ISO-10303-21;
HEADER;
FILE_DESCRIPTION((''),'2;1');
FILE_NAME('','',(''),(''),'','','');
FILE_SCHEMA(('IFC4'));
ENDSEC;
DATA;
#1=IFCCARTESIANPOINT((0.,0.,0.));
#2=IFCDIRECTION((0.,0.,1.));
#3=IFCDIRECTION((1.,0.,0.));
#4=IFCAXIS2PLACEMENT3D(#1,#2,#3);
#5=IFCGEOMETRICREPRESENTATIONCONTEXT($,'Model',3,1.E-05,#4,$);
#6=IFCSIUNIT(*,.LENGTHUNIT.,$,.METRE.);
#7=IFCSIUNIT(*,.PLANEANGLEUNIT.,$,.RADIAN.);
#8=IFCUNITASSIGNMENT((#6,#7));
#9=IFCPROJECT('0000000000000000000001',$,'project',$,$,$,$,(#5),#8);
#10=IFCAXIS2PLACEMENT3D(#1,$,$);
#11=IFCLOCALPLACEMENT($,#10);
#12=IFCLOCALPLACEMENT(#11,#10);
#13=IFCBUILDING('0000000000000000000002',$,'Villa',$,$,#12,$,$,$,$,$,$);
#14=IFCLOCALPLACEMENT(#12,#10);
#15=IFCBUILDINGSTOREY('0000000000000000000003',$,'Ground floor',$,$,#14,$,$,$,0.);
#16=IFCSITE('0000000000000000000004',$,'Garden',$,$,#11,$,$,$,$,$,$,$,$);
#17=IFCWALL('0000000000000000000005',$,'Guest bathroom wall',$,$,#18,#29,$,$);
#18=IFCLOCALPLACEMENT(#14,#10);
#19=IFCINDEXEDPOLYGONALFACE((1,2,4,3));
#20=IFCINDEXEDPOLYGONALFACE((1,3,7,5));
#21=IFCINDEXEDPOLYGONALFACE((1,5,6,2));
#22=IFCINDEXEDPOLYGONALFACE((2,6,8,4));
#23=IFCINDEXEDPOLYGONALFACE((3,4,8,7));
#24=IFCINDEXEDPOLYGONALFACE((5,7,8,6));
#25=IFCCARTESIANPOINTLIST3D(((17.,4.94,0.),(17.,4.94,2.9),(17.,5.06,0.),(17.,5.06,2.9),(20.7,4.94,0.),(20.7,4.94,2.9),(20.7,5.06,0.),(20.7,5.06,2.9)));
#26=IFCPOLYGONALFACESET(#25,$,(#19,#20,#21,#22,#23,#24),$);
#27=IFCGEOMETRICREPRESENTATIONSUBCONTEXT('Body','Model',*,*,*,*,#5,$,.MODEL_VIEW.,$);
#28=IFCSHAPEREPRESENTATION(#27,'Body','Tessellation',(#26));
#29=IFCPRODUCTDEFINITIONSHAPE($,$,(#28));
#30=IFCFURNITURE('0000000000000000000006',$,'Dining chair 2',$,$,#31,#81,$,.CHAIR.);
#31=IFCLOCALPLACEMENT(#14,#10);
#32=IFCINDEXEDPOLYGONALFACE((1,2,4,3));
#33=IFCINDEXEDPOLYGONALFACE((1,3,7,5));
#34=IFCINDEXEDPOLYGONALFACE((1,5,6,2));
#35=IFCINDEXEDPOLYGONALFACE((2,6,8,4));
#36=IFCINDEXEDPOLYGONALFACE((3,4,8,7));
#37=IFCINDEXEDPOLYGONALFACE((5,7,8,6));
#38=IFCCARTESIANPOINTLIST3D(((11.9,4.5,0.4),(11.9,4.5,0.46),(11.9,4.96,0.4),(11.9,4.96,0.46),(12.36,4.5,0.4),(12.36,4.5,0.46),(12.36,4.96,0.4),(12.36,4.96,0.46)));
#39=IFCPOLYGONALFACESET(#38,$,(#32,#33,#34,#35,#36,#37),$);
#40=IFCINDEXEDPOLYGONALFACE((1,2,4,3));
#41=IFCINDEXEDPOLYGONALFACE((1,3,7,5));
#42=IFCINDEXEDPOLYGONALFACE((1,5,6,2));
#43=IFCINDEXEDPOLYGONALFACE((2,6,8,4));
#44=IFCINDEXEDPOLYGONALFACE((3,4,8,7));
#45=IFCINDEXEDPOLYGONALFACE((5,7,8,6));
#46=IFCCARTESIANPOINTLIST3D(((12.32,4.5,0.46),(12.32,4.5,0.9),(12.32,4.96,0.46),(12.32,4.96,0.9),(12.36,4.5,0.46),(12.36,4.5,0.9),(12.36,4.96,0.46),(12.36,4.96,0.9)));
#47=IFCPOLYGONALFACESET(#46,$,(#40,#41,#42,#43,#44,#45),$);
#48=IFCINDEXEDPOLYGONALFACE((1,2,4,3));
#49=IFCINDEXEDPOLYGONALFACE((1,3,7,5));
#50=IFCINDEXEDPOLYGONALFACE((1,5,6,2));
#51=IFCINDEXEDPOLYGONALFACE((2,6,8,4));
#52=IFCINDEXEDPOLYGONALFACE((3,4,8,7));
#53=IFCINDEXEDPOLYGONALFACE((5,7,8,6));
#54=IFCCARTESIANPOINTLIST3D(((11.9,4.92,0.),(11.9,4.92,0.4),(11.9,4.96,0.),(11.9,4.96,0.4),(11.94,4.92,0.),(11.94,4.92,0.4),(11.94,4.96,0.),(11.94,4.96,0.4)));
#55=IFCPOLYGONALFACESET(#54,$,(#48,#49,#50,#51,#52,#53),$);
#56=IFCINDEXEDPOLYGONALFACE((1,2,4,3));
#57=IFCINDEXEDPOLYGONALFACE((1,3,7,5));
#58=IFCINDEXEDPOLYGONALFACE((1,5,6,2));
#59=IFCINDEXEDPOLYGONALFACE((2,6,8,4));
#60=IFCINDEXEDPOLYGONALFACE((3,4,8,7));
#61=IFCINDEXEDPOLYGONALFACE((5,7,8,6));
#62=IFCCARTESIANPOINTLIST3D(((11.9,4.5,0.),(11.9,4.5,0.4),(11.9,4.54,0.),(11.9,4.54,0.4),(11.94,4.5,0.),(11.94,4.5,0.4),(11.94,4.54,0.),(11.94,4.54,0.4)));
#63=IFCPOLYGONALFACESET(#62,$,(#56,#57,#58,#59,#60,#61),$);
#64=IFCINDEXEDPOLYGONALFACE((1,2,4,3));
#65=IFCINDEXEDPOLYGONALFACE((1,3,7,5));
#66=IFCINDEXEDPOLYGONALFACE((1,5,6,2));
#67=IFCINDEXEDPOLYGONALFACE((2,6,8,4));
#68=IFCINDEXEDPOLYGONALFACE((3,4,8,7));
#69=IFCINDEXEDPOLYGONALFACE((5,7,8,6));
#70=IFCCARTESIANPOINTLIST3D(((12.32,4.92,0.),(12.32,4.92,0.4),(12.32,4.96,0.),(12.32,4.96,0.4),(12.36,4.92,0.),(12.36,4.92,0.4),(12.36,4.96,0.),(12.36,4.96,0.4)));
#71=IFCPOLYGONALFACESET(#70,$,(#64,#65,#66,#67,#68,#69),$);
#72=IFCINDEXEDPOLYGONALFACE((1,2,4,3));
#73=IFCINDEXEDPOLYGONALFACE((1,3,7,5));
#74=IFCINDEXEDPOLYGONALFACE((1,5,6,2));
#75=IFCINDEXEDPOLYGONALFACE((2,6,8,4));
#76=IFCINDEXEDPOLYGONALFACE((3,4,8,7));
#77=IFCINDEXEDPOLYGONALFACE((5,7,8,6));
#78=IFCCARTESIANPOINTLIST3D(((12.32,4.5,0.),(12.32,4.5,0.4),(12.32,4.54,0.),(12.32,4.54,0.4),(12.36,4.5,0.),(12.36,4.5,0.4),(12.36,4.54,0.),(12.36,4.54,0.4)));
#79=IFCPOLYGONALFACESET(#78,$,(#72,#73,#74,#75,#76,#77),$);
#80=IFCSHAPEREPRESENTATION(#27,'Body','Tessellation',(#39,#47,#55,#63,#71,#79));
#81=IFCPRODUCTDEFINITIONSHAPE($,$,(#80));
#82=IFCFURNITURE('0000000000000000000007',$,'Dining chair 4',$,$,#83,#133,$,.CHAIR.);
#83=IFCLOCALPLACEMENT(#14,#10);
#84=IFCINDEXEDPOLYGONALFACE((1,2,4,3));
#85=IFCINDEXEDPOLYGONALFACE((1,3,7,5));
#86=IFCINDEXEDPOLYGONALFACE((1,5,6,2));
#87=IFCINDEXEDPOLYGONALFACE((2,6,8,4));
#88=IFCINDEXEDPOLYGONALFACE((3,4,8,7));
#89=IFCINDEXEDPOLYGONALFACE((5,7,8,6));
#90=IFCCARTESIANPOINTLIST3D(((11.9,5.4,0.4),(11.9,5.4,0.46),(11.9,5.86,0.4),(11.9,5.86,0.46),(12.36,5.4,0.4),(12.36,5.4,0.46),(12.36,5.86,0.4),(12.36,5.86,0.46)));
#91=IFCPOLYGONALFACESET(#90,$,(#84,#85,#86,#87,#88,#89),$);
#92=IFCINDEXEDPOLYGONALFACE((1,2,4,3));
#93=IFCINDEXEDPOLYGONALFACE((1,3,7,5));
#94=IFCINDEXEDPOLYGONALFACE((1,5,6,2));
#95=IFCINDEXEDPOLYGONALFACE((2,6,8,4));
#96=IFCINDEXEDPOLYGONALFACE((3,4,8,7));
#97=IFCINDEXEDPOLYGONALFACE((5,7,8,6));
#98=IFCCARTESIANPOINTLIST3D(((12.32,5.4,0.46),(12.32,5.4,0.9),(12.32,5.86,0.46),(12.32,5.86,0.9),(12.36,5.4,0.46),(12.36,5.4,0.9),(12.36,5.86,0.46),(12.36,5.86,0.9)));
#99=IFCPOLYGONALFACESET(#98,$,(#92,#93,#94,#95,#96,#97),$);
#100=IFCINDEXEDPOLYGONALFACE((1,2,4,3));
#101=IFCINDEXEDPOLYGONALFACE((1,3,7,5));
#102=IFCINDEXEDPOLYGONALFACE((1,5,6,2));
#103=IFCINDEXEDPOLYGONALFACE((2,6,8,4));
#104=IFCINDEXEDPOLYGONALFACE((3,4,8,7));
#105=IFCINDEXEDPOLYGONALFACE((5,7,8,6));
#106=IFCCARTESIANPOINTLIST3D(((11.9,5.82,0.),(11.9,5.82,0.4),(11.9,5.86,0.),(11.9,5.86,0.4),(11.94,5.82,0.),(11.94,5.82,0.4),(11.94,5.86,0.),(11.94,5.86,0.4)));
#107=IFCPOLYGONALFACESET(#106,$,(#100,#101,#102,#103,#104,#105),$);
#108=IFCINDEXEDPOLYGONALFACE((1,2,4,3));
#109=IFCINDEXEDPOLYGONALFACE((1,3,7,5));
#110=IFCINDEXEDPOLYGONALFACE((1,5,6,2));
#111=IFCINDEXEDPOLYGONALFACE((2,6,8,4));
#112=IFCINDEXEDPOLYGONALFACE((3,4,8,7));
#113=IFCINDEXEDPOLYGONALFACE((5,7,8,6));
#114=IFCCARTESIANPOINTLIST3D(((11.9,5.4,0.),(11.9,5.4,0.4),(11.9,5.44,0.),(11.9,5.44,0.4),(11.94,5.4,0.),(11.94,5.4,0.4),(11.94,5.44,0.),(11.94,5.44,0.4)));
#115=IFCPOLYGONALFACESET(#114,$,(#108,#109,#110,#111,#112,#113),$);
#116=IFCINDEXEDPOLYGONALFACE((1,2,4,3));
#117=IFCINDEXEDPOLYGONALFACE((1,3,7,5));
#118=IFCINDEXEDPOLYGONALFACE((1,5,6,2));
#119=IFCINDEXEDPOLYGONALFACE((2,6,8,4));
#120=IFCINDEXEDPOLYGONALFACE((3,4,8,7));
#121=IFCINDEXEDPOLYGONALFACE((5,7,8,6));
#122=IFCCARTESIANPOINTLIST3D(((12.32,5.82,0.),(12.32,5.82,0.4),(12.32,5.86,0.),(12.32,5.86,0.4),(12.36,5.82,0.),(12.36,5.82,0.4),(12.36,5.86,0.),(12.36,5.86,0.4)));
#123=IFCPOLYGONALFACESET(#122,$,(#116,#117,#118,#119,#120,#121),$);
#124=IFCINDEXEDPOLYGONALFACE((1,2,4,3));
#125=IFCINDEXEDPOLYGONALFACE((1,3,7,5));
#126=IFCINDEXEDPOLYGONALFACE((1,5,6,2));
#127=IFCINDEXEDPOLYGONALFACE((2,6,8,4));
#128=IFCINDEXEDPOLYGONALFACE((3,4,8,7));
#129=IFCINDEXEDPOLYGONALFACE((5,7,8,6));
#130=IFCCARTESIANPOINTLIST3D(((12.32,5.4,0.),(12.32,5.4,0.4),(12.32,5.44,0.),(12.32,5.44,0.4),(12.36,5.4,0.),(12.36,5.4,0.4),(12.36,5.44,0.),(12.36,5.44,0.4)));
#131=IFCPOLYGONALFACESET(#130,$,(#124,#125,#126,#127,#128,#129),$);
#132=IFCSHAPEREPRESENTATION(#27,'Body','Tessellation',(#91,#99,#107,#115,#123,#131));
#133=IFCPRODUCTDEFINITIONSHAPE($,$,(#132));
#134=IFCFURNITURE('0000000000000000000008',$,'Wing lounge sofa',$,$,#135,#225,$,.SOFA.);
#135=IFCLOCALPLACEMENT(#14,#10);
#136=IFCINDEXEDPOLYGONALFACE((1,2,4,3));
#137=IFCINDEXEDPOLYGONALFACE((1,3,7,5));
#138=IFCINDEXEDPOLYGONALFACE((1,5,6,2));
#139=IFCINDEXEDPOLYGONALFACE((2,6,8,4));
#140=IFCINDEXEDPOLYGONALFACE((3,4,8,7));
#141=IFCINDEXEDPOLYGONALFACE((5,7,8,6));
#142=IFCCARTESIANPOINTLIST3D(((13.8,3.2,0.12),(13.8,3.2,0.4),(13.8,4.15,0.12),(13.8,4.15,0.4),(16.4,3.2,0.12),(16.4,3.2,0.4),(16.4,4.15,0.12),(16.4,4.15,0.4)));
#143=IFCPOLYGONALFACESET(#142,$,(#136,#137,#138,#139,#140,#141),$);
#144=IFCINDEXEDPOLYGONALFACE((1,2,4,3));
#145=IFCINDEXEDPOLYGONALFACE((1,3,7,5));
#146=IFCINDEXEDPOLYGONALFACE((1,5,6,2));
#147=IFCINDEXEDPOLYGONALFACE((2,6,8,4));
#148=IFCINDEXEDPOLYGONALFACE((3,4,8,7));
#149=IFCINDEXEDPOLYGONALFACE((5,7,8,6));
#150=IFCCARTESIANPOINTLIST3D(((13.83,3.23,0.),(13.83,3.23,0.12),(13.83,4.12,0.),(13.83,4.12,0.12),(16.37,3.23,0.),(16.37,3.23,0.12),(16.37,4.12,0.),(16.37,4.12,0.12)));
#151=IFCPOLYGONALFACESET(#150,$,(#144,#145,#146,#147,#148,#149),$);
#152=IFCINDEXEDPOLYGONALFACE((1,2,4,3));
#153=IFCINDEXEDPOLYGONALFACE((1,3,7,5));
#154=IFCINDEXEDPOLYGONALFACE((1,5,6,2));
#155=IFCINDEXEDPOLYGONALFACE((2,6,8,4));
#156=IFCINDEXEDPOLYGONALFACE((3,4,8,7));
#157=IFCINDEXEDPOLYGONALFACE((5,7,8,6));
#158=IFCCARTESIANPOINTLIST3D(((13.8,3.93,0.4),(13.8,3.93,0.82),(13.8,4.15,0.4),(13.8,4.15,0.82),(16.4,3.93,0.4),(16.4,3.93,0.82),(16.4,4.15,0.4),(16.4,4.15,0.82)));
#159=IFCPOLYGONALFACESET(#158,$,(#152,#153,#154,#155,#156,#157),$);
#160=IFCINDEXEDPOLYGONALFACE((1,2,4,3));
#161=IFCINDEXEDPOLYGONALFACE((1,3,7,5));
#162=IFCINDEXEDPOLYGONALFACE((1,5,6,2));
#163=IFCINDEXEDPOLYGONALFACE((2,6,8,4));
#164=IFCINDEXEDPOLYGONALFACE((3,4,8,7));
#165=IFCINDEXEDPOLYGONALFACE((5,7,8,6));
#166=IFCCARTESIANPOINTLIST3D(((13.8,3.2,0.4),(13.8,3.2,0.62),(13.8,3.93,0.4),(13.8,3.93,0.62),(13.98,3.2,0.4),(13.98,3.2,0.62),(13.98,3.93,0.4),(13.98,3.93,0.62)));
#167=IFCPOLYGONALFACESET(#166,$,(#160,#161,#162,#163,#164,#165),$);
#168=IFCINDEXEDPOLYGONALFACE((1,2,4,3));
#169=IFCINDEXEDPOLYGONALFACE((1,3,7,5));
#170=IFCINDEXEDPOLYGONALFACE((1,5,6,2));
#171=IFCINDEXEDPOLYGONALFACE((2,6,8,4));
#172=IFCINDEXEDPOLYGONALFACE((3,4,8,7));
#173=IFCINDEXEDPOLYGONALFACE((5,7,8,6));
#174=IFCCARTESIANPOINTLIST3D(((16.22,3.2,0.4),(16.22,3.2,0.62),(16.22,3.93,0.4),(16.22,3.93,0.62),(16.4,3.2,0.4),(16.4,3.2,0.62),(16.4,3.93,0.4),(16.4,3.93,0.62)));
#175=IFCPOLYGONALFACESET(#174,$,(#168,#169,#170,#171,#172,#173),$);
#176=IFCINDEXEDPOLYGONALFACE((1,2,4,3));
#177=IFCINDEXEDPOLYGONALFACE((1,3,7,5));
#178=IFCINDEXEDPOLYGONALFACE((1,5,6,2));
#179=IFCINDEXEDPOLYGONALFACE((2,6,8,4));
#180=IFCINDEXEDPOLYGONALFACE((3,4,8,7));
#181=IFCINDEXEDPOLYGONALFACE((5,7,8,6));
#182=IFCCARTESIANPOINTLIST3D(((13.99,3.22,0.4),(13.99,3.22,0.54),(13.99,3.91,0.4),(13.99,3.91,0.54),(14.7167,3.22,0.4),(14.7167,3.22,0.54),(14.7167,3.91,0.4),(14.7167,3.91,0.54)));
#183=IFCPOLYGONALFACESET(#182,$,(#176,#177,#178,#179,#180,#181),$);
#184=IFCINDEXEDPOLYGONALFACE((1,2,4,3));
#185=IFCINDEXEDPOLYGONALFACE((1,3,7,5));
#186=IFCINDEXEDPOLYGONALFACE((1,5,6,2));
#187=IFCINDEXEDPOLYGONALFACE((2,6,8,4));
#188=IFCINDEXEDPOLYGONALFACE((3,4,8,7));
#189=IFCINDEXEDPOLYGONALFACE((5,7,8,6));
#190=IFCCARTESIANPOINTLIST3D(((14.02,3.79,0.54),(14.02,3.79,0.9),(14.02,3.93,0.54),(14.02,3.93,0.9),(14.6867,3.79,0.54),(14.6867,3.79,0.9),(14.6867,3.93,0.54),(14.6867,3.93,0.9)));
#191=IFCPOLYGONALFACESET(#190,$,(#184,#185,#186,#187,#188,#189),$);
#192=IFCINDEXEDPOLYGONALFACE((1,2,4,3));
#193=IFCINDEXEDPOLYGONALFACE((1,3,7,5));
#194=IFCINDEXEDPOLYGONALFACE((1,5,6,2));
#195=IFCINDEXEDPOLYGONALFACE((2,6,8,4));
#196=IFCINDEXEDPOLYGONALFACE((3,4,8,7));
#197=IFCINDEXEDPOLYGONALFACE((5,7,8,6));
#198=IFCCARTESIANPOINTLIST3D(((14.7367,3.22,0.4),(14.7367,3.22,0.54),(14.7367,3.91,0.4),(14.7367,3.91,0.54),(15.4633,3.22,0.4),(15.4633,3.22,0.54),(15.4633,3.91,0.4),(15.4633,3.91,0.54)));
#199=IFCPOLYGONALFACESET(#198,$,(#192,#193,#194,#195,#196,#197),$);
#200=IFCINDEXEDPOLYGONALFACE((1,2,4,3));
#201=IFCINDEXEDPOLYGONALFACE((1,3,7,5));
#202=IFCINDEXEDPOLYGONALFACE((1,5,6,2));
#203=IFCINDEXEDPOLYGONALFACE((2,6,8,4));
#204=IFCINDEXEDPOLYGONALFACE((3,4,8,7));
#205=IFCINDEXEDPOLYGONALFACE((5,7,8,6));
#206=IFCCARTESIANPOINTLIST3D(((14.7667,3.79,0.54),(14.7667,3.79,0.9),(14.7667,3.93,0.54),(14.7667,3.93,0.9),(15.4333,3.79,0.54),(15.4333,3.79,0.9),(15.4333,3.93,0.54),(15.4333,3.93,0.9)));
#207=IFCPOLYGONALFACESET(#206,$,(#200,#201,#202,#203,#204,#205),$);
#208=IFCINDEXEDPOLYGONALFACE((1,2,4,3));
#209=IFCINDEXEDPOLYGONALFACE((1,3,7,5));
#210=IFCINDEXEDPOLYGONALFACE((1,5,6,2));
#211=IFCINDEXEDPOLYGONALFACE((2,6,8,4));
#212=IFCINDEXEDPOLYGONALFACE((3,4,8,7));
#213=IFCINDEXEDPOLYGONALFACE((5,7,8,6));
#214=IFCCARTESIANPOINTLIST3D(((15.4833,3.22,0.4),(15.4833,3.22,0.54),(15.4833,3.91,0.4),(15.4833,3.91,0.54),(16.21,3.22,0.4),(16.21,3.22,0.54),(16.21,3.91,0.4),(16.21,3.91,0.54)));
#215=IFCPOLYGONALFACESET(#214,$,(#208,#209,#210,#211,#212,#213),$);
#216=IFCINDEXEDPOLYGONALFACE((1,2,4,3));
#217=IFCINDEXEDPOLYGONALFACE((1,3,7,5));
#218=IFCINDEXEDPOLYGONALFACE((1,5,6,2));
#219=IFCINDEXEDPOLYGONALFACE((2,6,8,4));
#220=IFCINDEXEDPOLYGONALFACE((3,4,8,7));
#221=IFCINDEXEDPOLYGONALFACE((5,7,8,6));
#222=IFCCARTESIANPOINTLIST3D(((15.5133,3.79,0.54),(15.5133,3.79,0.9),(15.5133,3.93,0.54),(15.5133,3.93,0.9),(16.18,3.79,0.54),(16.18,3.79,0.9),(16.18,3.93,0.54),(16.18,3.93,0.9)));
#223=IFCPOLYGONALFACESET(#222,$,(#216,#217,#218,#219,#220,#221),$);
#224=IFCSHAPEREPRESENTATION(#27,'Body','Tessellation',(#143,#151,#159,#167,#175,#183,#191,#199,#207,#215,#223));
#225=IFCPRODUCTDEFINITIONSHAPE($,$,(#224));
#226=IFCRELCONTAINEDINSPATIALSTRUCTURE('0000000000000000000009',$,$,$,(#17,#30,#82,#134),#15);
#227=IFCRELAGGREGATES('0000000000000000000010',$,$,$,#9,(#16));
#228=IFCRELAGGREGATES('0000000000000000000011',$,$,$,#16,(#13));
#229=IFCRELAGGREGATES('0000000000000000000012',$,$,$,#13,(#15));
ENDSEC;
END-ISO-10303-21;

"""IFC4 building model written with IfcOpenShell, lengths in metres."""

from ifc_helpers import new_model, si_unit, frame, frame_2d, origin, origin_with_axes, place, context, subcontext, project, spatial, rectangle, extrude, element, save


model = new_model("IFC4")

# Units and contexts
model_context = context("Model", 3, precision=1e-05, world=origin_with_axes())
body_context = subcontext(model_context, "Body", "Model", "MODEL_VIEW")
ifc_project = project(units=[si_unit("LENGTHUNIT", "METRE"), si_unit("PLANEANGLEUNIT", "RADIAN")], contexts=[model_context])

# Site, building, storey
site_placement = place(None, origin())
site = spatial("IfcSite", under=ifc_project, at=site_placement, Name="Garden")
building_placement = place(site_placement, origin())
building = spatial("IfcBuilding", under=site, at=building_placement, Name="Villa")
storey_placement = place(building_placement, origin())
storey = spatial("IfcBuildingStorey", under=building, at=storey_placement, Name="Ground floor", Elevation=0.0)

# Wall
wall_1_placement = place(storey_placement, frame((17.0, 5.0, 0.0)))
element("IfcWall", 1, at=wall_1_placement, inside=storey, Name="Guest bathroom wall", context=body_context, shape_type="SweptSolid", body=[
    extrude(rectangle(XDim=3.7, YDim=0.12, at=frame_2d((1.85, 0.0))), origin(), (0.0, 0.0, 1.0), 2.9),
])

# Furniture
for number, where, x_axis, name in (
    (2, (11.9, 4.96, 0.0), (0.0, -1.0, 0.0), "Dining chair 2"),
    (3, (11.9, 5.86, 0.0), (0.0, -1.0, 0.0), "Dining chair 4"),
):
    element("IfcFurniture", number, at=place(storey_placement, frame(where, x_axis=x_axis)), inside=storey, Name=name, PredefinedType="CHAIR", context=body_context, shape_type="SweptSolid", body=[
        extrude(rectangle(XDim=0.46, YDim=0.46, at=frame_2d((0.23, 0.23))), frame((0.0, 0.0, 0.4)), (0.0, 0.0, 1.0), 0.06),
        extrude(rectangle(XDim=0.46, YDim=0.04, at=frame_2d((0.23, 0.02))), frame((0.0, 0.42, 0.46)), (0.0, 0.0, 1.0), 0.44),
        extrude(rectangle(XDim=0.04, YDim=0.04, at=frame_2d((0.02, 0.02))), origin(), (0.0, 0.0, 1.0), 0.4),
        extrude(rectangle(XDim=0.04, YDim=0.04, at=frame_2d((0.02, 0.02))), frame((0.42, 0.0, 0.0)), (0.0, 0.0, 1.0), 0.4),
        extrude(rectangle(XDim=0.04, YDim=0.04, at=frame_2d((0.02, 0.02))), frame((0.0, 0.42, 0.0)), (0.0, 0.0, 1.0), 0.4),
        extrude(rectangle(XDim=0.04, YDim=0.04, at=frame_2d((0.02, 0.02))), frame((0.42, 0.42, 0.0)), (0.0, 0.0, 1.0), 0.4),
    ])
furniture_1_placement = place(storey_placement, frame((13.8, 3.2, 0.0)))
element("IfcFurniture", 4, at=furniture_1_placement, inside=storey, Name="Wing lounge sofa", PredefinedType="SOFA", context=body_context, shape_type="SweptSolid", body=[
    extrude(rectangle(XDim=2.6, YDim=0.95, at=frame_2d((1.3, 0.475))), frame((0.0, 0.0, 0.12)), (0.0, 0.0, 1.0), 0.28),
    extrude(rectangle(XDim=2.54, YDim=0.89, at=frame_2d((1.27, 0.445))), frame((0.03, 0.03, 0.0)), (0.0, 0.0, 1.0), 0.12),
    extrude(rectangle(XDim=2.6, YDim=0.22, at=frame_2d((1.3, 0.11))), frame((0.0, 0.73, 0.4)), (0.0, 0.0, 1.0), 0.42),
    extrude(rectangle(XDim=0.18, YDim=0.73, at=frame_2d((0.09, 0.365))), frame((0.0, 0.0, 0.4)), (0.0, 0.0, 1.0), 0.22),
    extrude(rectangle(XDim=0.18, YDim=0.73, at=frame_2d((0.09, 0.365))), frame((2.42, 0.0, 0.4)), (0.0, 0.0, 1.0), 0.22),
    extrude(rectangle(XDim=0.7267, YDim=0.69, at=frame_2d((0.3633, 0.345))), frame((0.19, 0.02, 0.4)), (0.0, 0.0, 1.0), 0.14),
    extrude(rectangle(XDim=0.6667, YDim=0.14, at=frame_2d((0.3333, 0.07))), frame((0.22, 0.59, 0.54)), (0.0, 0.0, 1.0), 0.36),
    extrude(rectangle(XDim=0.7267, YDim=0.69, at=frame_2d((0.3633, 0.345))), frame((0.9367, 0.02, 0.4)), (0.0, 0.0, 1.0), 0.14),
    extrude(rectangle(XDim=0.6667, YDim=0.14, at=frame_2d((0.3333, 0.07))), frame((0.9667, 0.59, 0.54)), (0.0, 0.0, 1.0), 0.36),
    extrude(rectangle(XDim=0.7267, YDim=0.69, at=frame_2d((0.3633, 0.345))), frame((1.6833, 0.02, 0.4)), (0.0, 0.0, 1.0), 0.14),
    extrude(rectangle(XDim=0.6667, YDim=0.14, at=frame_2d((0.3333, 0.07))), frame((1.7133, 0.59, 0.54)), (0.0, 0.0, 1.0), 0.36),
])

save(model, "model.ifc")
